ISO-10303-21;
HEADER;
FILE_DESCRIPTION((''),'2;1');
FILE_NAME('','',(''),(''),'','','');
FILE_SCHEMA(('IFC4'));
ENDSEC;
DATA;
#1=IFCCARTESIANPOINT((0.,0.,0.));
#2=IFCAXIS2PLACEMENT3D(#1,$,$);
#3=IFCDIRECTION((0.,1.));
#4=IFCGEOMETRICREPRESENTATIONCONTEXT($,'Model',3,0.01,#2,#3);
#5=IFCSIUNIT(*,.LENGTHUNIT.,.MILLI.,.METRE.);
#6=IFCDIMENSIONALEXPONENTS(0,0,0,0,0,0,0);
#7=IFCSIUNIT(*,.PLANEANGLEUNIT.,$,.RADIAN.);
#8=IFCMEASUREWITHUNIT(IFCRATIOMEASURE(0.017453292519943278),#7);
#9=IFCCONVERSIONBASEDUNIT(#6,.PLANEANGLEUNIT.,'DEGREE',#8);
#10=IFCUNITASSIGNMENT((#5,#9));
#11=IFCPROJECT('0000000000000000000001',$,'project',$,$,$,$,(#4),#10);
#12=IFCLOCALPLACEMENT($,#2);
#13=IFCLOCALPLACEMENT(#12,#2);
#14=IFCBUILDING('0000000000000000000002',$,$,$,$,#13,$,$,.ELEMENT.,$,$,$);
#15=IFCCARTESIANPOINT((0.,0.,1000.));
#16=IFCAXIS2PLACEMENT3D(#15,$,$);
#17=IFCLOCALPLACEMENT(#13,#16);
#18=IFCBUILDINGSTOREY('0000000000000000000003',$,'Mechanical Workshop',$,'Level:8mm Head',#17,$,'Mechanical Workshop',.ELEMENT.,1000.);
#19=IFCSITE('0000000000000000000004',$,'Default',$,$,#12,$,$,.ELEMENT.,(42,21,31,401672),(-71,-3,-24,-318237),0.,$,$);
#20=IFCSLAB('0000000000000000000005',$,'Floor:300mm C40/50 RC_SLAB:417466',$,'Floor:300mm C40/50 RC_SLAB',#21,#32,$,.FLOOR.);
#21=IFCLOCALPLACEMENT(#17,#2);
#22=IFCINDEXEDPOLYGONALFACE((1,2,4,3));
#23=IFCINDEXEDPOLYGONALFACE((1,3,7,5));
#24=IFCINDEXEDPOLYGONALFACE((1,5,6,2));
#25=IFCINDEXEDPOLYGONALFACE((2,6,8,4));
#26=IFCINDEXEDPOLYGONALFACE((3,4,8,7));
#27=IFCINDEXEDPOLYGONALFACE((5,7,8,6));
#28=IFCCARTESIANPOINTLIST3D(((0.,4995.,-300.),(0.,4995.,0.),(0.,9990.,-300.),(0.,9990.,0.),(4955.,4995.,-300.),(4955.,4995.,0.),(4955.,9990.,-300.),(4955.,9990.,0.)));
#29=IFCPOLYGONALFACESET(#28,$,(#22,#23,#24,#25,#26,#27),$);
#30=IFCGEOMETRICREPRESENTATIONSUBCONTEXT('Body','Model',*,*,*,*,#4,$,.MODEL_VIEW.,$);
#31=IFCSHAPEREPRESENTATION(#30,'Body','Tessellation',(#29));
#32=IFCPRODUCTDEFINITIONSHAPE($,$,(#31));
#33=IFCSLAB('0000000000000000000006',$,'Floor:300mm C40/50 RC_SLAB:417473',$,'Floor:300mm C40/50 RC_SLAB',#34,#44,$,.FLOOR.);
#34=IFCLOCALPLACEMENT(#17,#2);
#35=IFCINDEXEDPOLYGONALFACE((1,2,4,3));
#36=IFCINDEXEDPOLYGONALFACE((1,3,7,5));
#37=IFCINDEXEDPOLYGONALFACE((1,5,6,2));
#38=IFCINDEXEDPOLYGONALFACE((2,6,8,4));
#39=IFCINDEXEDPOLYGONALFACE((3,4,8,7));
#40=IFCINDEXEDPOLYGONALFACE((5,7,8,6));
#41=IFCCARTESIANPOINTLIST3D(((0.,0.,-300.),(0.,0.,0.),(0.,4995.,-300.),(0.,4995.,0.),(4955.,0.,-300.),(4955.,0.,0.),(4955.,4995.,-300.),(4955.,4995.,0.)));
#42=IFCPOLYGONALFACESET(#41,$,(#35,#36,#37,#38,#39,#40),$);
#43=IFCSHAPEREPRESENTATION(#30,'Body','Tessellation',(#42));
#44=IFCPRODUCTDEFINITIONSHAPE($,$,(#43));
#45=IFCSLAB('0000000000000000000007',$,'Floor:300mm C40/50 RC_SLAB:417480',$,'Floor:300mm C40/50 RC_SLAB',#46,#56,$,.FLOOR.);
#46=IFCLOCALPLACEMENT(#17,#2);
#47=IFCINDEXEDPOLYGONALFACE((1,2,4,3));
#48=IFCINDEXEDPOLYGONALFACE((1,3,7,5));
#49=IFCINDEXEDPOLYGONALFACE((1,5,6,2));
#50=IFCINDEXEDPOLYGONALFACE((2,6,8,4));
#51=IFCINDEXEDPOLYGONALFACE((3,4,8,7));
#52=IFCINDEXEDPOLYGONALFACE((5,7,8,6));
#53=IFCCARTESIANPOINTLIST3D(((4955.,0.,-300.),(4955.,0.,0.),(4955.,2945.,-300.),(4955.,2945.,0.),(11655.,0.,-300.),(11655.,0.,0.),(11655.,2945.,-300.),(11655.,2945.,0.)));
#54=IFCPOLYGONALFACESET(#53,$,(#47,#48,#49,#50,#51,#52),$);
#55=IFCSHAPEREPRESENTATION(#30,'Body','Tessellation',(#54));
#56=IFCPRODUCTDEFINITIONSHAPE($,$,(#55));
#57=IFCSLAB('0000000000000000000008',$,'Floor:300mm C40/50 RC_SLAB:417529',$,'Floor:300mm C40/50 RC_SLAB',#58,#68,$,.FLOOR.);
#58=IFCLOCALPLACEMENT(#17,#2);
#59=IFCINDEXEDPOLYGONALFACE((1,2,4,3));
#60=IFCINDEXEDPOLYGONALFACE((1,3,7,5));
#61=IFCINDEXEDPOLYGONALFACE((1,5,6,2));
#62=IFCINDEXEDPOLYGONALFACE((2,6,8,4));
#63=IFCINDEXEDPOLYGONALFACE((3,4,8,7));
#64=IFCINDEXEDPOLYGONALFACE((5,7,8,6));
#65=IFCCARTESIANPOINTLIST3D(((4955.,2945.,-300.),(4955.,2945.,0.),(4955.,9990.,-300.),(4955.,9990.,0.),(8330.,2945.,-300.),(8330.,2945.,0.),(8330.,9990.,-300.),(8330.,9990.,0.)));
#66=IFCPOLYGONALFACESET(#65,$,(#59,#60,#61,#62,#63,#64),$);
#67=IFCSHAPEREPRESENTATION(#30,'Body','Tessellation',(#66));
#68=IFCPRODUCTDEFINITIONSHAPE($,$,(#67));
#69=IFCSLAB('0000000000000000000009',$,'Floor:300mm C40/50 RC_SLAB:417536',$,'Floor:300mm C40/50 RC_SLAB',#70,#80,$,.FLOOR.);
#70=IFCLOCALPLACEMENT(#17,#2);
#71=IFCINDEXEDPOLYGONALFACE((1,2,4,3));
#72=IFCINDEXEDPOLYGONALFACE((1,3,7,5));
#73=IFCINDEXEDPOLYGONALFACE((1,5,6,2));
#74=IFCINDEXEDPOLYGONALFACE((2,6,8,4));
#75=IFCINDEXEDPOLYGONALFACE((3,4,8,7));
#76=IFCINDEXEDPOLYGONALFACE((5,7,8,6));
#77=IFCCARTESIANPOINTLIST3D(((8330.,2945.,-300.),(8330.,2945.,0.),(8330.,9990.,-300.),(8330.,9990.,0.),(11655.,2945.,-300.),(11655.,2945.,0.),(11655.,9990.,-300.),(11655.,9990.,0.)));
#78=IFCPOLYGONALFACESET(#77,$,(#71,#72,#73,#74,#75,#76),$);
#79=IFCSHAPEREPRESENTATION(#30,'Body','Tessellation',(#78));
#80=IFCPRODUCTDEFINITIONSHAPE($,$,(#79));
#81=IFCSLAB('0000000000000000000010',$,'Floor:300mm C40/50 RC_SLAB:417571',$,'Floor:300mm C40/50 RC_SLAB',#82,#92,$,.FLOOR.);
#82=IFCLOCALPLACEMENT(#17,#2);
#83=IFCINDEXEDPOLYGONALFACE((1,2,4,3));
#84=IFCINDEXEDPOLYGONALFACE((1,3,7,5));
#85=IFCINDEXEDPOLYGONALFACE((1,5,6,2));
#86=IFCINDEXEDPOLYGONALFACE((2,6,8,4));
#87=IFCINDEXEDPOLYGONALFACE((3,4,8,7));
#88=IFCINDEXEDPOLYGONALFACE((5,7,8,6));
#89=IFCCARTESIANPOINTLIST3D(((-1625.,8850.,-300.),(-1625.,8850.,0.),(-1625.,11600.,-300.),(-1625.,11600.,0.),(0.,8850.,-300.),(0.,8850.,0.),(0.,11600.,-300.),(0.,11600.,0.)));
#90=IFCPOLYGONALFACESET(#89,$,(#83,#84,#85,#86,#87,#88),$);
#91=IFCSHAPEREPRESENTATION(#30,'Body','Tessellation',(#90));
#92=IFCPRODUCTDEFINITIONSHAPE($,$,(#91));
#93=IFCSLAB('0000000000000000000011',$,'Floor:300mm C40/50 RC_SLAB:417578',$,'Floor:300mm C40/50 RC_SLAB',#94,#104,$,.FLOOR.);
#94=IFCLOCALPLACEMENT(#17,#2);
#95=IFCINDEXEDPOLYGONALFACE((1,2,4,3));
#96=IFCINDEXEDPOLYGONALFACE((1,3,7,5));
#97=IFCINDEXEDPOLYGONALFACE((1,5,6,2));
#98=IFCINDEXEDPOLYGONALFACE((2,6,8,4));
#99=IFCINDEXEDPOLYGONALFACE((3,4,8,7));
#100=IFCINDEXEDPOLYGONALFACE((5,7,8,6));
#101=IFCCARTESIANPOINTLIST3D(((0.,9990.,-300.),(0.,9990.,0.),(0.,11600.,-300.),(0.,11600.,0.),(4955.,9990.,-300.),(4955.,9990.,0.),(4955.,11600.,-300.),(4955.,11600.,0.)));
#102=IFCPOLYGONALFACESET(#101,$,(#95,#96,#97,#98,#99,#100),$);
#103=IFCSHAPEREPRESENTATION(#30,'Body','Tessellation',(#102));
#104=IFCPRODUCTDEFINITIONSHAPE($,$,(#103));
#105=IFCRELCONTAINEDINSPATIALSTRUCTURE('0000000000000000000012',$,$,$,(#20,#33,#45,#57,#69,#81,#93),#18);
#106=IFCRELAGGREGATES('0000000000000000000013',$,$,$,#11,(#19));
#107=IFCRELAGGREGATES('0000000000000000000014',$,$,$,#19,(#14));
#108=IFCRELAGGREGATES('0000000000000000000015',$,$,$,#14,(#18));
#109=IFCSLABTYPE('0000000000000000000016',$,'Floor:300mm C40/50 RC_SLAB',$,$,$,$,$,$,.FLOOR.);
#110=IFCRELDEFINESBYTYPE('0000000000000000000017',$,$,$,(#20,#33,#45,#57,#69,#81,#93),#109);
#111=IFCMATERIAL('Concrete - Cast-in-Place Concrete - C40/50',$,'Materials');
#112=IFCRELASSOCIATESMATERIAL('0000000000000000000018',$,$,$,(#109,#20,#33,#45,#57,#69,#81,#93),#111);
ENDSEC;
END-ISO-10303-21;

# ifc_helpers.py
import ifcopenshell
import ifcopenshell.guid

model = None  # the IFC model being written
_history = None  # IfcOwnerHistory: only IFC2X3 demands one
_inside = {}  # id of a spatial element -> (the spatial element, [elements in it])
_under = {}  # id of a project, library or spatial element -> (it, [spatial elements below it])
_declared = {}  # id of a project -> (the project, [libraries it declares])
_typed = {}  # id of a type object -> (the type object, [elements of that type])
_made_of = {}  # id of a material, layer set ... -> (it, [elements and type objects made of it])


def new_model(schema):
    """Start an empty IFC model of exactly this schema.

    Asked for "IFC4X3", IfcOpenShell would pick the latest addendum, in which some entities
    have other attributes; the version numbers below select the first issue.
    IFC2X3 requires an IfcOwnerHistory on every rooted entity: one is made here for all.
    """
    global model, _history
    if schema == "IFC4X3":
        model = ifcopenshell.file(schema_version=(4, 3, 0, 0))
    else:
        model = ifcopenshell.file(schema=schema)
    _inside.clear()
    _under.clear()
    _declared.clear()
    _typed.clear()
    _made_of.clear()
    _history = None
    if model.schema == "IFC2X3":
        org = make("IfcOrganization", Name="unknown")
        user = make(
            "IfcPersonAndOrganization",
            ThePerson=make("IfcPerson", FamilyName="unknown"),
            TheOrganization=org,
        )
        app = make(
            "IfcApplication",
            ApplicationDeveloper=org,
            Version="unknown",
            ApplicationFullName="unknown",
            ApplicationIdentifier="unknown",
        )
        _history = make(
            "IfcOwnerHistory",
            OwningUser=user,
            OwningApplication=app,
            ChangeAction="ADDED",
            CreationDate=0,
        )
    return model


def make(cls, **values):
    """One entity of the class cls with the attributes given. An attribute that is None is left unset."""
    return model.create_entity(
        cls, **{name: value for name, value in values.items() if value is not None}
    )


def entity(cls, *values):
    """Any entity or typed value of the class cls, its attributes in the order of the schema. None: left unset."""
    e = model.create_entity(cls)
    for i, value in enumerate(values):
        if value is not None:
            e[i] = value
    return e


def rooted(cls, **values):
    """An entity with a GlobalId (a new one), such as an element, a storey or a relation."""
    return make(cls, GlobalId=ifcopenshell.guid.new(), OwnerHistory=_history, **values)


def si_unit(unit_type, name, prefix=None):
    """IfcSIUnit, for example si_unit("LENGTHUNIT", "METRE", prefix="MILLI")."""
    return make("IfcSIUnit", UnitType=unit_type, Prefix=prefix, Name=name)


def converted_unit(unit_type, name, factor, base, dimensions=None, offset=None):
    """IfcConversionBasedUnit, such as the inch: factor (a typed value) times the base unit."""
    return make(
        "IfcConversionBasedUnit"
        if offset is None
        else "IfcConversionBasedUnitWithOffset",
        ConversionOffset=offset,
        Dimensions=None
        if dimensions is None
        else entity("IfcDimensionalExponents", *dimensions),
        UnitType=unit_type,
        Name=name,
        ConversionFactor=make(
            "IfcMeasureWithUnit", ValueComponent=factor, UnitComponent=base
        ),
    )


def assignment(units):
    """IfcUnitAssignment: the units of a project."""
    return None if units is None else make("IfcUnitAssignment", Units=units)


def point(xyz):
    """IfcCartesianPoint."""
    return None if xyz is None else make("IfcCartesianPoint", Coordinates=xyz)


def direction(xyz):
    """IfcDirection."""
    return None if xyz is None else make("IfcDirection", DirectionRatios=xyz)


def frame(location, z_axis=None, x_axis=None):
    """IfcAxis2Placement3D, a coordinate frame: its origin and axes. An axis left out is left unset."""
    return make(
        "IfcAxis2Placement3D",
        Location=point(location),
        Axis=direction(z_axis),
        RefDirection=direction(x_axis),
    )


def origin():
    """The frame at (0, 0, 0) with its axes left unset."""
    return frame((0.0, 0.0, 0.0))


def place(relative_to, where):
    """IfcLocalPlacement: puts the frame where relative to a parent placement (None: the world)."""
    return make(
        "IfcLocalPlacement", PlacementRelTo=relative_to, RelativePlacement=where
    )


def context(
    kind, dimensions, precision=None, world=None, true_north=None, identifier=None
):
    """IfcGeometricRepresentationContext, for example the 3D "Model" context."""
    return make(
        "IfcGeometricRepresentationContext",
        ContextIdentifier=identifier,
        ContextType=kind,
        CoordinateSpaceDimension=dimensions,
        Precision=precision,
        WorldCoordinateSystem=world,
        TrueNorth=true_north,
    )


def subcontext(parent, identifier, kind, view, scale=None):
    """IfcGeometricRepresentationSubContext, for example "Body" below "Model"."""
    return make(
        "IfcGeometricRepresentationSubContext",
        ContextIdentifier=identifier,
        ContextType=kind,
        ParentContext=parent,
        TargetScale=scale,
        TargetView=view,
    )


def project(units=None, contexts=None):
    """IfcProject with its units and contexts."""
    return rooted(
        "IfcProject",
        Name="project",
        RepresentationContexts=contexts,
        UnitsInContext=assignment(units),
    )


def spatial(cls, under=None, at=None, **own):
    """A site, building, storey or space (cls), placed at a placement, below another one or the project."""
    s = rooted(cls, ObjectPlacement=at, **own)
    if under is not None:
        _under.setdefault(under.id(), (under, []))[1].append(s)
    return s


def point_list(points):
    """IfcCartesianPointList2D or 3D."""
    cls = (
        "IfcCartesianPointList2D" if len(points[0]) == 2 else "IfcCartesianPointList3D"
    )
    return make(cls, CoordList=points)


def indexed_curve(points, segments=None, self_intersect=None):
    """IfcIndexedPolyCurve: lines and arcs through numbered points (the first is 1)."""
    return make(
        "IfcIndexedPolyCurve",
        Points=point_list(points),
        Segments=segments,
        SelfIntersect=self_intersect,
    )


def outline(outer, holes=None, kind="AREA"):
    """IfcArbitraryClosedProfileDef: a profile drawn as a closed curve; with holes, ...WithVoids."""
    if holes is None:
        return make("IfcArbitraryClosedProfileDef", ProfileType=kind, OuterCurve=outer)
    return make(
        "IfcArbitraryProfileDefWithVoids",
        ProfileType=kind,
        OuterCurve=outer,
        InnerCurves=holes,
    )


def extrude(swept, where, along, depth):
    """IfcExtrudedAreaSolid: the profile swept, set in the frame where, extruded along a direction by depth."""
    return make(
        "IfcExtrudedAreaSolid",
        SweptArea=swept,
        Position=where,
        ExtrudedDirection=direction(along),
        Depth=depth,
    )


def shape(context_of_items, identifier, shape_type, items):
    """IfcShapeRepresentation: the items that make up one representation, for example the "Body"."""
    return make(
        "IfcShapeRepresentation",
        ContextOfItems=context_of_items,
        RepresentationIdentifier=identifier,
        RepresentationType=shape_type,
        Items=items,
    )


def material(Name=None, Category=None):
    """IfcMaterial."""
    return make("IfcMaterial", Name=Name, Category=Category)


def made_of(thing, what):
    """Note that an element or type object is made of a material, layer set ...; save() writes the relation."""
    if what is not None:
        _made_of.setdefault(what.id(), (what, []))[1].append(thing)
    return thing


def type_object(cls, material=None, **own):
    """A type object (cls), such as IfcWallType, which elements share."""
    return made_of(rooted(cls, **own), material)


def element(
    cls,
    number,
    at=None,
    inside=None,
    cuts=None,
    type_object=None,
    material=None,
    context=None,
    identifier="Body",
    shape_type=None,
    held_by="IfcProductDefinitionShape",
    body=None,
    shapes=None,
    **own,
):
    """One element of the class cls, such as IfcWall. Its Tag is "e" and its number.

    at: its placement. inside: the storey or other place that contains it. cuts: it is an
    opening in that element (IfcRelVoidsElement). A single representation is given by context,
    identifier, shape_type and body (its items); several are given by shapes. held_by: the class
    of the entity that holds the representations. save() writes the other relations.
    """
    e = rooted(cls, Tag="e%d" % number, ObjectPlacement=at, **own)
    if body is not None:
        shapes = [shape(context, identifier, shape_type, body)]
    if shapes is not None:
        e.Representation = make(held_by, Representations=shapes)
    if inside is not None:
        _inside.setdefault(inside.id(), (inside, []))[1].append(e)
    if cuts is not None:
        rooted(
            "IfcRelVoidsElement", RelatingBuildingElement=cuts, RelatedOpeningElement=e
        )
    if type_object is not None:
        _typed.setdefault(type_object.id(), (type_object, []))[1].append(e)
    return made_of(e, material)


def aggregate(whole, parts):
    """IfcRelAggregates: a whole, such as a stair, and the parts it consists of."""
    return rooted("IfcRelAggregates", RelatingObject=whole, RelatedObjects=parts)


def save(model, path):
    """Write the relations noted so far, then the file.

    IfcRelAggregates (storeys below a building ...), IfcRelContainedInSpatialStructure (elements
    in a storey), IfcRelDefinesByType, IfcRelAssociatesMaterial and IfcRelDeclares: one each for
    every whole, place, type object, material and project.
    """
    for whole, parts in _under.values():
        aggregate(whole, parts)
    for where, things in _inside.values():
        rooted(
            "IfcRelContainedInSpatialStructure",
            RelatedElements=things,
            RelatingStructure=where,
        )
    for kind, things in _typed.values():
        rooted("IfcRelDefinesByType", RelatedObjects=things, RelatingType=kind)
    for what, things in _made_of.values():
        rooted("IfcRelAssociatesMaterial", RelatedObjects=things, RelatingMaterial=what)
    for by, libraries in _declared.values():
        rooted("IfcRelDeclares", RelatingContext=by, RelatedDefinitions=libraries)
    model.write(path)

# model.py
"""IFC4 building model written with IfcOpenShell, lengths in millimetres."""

from ifc_helpers import new_model, entity, si_unit, converted_unit, direction, frame, origin, place, context, subcontext, project, spatial, indexed_curve, outline, extrude, material, type_object, element, save


model = new_model("IFC4")

# Units and contexts
model_context = context("Model", 3, precision=0.01, world=origin(), true_north=direction((0.0, 1.0)))
body_context = subcontext(model_context, "Body", "Model", "MODEL_VIEW")
ifc_project = project(units=[si_unit("LENGTHUNIT", "METRE", prefix="MILLI"), converted_unit("PLANEANGLEUNIT", "DEGREE", entity("IfcRatioMeasure", 0.017453292519943278), si_unit("PLANEANGLEUNIT", "RADIAN"), dimensions=[0, 0, 0, 0, 0, 0, 0])], contexts=[model_context])

# Site, building, storey
site_placement = place(None, origin())
site = spatial("IfcSite", under=ifc_project, at=site_placement, Name="Default", CompositionType="ELEMENT", RefLatitude=(42, 21, 31, 401672), RefLongitude=(-71, -3, -24, -318237), RefElevation=0.0)
building_placement = place(site_placement, origin())
building = spatial("IfcBuilding", under=site, at=building_placement, CompositionType="ELEMENT")
storey_placement = place(building_placement, frame((0.0, 0.0, 1000.0)))
storey = spatial("IfcBuildingStorey", under=building, at=storey_placement, Name="Mechanical Workshop", ObjectType="Level:8mm Head", LongName="Mechanical Workshop", CompositionType="ELEMENT", Elevation=1000.0)

# Shared definitions
ifc_material_1 = material(Name="Concrete - Cast-in-Place Concrete - C40/50", Category="Materials")

# Slabs
slab_type = type_object("IfcSlabType", Name="Floor:300mm C40/50 RC_SLAB", PredefinedType="FLOOR", material=ifc_material_1)
slab_1_placement = place(storey_placement, origin())
element("IfcSlab", 1, at=slab_1_placement, inside=storey, type_object=slab_type, material=ifc_material_1, Name="Floor:300mm C40/50 RC_SLAB:417466", ObjectType="Floor:300mm C40/50 RC_SLAB", PredefinedType="FLOOR", context=body_context, shape_type="SweptSolid", body=[
    extrude(outline(indexed_curve([(-2497.5, -2477.5), (2497.5, -2477.5), (2497.5, 2477.5), (-2497.5, 2477.5), (-2497.5, -2477.5)], self_intersect=False)), frame((2477.5, 7492.5, 0.0), z_axis=(0.0, 0.0, -1.0), x_axis=(0.0, 1.0, 0.0)), (0.0, 0.0, 1.0), 300.0),
])
slab_2_placement = place(storey_placement, origin())
element("IfcSlab", 2, at=slab_2_placement, inside=storey, type_object=slab_type, material=ifc_material_1, Name="Floor:300mm C40/50 RC_SLAB:417473", ObjectType="Floor:300mm C40/50 RC_SLAB", PredefinedType="FLOOR", context=body_context, shape_type="SweptSolid", body=[
    extrude(outline(indexed_curve([(-2497.5, -2477.5), (2497.5, -2477.5), (2497.5, 2477.5), (-2497.5, 2477.5), (-2497.5, -2477.5)], self_intersect=False)), frame((2477.5, 2497.5, 0.0), z_axis=(0.0, 0.0, -1.0), x_axis=(0.0, 1.0, 0.0)), (0.0, 0.0, 1.0), 300.0),
])
slab_3_placement = place(storey_placement, origin())
element("IfcSlab", 3, at=slab_3_placement, inside=storey, type_object=slab_type, material=ifc_material_1, Name="Floor:300mm C40/50 RC_SLAB:417480", ObjectType="Floor:300mm C40/50 RC_SLAB", PredefinedType="FLOOR", context=body_context, shape_type="SweptSolid", body=[
    extrude(outline(indexed_curve([(-1472.5, -3350.0), (1472.5, -3350.0), (1472.5, 3350.0), (-1472.5, 3350.0), (-1472.5, -3350.0)], self_intersect=False)), frame((8305.0, 1472.5, 0.0), z_axis=(0.0, 0.0, -1.0), x_axis=(0.0, 1.0, 0.0)), (0.0, 0.0, 1.0), 300.0),
])
slab_4_placement = place(storey_placement, origin())
element("IfcSlab", 4, at=slab_4_placement, inside=storey, type_object=slab_type, material=ifc_material_1, Name="Floor:300mm C40/50 RC_SLAB:417529", ObjectType="Floor:300mm C40/50 RC_SLAB", PredefinedType="FLOOR", context=body_context, shape_type="SweptSolid", body=[
    extrude(outline(indexed_curve([(-3522.5, -1687.5), (3522.5, -1687.5), (3522.5, 1687.5), (-3522.5, 1687.5), (-3522.5, -1687.5)], self_intersect=False)), frame((6642.5, 6467.5, 0.0), z_axis=(0.0, 0.0, -1.0), x_axis=(0.0, 1.0, 0.0)), (0.0, 0.0, 1.0), 300.0),
])
slab_5_placement = place(storey_placement, origin())
element("IfcSlab", 5, at=slab_5_placement, inside=storey, type_object=slab_type, material=ifc_material_1, Name="Floor:300mm C40/50 RC_SLAB:417536", ObjectType="Floor:300mm C40/50 RC_SLAB", PredefinedType="FLOOR", context=body_context, shape_type="SweptSolid", body=[
    extrude(outline(indexed_curve([(-3522.5, -1662.5), (3522.5, -1662.5), (3522.5, 1662.5), (-3522.5, 1662.5), (-3522.5, -1662.5)], self_intersect=False)), frame((9992.5, 6467.5, 0.0), z_axis=(0.0, 0.0, -1.0), x_axis=(0.0, 1.0, 0.0)), (0.0, 0.0, 1.0), 300.0),
])
slab_6_placement = place(storey_placement, origin())
element("IfcSlab", 6, at=slab_6_placement, inside=storey, type_object=slab_type, material=ifc_material_1, Name="Floor:300mm C40/50 RC_SLAB:417571", ObjectType="Floor:300mm C40/50 RC_SLAB", PredefinedType="FLOOR", context=body_context, shape_type="SweptSolid", body=[
    extrude(outline(indexed_curve([(-1375.0, -812.5), (1375.0, -812.5), (1375.0, 812.5), (-1375.0, 812.5), (-1375.0, -812.5)], self_intersect=False)), frame((-812.5, 10225.0, 0.0), z_axis=(0.0, 0.0, -1.0), x_axis=(0.0, 1.0, 0.0)), (0.0, 0.0, 1.0), 300.0),
])
slab_7_placement = place(storey_placement, origin())
element("IfcSlab", 7, at=slab_7_placement, inside=storey, type_object=slab_type, material=ifc_material_1, Name="Floor:300mm C40/50 RC_SLAB:417578", ObjectType="Floor:300mm C40/50 RC_SLAB", PredefinedType="FLOOR", context=body_context, shape_type="SweptSolid", body=[
    extrude(outline(indexed_curve([(-805.0, -2477.5), (805.0, -2477.5), (805.0, 2477.5), (-805.0, 2477.5), (-805.0, -2477.5)], self_intersect=False)), frame((2477.5, 10795.0, 0.0), z_axis=(0.0, 0.0, -1.0), x_axis=(0.0, 1.0, 0.0)), (0.0, 0.0, 1.0), 300.0),
])

save(model, "model.ifc")
